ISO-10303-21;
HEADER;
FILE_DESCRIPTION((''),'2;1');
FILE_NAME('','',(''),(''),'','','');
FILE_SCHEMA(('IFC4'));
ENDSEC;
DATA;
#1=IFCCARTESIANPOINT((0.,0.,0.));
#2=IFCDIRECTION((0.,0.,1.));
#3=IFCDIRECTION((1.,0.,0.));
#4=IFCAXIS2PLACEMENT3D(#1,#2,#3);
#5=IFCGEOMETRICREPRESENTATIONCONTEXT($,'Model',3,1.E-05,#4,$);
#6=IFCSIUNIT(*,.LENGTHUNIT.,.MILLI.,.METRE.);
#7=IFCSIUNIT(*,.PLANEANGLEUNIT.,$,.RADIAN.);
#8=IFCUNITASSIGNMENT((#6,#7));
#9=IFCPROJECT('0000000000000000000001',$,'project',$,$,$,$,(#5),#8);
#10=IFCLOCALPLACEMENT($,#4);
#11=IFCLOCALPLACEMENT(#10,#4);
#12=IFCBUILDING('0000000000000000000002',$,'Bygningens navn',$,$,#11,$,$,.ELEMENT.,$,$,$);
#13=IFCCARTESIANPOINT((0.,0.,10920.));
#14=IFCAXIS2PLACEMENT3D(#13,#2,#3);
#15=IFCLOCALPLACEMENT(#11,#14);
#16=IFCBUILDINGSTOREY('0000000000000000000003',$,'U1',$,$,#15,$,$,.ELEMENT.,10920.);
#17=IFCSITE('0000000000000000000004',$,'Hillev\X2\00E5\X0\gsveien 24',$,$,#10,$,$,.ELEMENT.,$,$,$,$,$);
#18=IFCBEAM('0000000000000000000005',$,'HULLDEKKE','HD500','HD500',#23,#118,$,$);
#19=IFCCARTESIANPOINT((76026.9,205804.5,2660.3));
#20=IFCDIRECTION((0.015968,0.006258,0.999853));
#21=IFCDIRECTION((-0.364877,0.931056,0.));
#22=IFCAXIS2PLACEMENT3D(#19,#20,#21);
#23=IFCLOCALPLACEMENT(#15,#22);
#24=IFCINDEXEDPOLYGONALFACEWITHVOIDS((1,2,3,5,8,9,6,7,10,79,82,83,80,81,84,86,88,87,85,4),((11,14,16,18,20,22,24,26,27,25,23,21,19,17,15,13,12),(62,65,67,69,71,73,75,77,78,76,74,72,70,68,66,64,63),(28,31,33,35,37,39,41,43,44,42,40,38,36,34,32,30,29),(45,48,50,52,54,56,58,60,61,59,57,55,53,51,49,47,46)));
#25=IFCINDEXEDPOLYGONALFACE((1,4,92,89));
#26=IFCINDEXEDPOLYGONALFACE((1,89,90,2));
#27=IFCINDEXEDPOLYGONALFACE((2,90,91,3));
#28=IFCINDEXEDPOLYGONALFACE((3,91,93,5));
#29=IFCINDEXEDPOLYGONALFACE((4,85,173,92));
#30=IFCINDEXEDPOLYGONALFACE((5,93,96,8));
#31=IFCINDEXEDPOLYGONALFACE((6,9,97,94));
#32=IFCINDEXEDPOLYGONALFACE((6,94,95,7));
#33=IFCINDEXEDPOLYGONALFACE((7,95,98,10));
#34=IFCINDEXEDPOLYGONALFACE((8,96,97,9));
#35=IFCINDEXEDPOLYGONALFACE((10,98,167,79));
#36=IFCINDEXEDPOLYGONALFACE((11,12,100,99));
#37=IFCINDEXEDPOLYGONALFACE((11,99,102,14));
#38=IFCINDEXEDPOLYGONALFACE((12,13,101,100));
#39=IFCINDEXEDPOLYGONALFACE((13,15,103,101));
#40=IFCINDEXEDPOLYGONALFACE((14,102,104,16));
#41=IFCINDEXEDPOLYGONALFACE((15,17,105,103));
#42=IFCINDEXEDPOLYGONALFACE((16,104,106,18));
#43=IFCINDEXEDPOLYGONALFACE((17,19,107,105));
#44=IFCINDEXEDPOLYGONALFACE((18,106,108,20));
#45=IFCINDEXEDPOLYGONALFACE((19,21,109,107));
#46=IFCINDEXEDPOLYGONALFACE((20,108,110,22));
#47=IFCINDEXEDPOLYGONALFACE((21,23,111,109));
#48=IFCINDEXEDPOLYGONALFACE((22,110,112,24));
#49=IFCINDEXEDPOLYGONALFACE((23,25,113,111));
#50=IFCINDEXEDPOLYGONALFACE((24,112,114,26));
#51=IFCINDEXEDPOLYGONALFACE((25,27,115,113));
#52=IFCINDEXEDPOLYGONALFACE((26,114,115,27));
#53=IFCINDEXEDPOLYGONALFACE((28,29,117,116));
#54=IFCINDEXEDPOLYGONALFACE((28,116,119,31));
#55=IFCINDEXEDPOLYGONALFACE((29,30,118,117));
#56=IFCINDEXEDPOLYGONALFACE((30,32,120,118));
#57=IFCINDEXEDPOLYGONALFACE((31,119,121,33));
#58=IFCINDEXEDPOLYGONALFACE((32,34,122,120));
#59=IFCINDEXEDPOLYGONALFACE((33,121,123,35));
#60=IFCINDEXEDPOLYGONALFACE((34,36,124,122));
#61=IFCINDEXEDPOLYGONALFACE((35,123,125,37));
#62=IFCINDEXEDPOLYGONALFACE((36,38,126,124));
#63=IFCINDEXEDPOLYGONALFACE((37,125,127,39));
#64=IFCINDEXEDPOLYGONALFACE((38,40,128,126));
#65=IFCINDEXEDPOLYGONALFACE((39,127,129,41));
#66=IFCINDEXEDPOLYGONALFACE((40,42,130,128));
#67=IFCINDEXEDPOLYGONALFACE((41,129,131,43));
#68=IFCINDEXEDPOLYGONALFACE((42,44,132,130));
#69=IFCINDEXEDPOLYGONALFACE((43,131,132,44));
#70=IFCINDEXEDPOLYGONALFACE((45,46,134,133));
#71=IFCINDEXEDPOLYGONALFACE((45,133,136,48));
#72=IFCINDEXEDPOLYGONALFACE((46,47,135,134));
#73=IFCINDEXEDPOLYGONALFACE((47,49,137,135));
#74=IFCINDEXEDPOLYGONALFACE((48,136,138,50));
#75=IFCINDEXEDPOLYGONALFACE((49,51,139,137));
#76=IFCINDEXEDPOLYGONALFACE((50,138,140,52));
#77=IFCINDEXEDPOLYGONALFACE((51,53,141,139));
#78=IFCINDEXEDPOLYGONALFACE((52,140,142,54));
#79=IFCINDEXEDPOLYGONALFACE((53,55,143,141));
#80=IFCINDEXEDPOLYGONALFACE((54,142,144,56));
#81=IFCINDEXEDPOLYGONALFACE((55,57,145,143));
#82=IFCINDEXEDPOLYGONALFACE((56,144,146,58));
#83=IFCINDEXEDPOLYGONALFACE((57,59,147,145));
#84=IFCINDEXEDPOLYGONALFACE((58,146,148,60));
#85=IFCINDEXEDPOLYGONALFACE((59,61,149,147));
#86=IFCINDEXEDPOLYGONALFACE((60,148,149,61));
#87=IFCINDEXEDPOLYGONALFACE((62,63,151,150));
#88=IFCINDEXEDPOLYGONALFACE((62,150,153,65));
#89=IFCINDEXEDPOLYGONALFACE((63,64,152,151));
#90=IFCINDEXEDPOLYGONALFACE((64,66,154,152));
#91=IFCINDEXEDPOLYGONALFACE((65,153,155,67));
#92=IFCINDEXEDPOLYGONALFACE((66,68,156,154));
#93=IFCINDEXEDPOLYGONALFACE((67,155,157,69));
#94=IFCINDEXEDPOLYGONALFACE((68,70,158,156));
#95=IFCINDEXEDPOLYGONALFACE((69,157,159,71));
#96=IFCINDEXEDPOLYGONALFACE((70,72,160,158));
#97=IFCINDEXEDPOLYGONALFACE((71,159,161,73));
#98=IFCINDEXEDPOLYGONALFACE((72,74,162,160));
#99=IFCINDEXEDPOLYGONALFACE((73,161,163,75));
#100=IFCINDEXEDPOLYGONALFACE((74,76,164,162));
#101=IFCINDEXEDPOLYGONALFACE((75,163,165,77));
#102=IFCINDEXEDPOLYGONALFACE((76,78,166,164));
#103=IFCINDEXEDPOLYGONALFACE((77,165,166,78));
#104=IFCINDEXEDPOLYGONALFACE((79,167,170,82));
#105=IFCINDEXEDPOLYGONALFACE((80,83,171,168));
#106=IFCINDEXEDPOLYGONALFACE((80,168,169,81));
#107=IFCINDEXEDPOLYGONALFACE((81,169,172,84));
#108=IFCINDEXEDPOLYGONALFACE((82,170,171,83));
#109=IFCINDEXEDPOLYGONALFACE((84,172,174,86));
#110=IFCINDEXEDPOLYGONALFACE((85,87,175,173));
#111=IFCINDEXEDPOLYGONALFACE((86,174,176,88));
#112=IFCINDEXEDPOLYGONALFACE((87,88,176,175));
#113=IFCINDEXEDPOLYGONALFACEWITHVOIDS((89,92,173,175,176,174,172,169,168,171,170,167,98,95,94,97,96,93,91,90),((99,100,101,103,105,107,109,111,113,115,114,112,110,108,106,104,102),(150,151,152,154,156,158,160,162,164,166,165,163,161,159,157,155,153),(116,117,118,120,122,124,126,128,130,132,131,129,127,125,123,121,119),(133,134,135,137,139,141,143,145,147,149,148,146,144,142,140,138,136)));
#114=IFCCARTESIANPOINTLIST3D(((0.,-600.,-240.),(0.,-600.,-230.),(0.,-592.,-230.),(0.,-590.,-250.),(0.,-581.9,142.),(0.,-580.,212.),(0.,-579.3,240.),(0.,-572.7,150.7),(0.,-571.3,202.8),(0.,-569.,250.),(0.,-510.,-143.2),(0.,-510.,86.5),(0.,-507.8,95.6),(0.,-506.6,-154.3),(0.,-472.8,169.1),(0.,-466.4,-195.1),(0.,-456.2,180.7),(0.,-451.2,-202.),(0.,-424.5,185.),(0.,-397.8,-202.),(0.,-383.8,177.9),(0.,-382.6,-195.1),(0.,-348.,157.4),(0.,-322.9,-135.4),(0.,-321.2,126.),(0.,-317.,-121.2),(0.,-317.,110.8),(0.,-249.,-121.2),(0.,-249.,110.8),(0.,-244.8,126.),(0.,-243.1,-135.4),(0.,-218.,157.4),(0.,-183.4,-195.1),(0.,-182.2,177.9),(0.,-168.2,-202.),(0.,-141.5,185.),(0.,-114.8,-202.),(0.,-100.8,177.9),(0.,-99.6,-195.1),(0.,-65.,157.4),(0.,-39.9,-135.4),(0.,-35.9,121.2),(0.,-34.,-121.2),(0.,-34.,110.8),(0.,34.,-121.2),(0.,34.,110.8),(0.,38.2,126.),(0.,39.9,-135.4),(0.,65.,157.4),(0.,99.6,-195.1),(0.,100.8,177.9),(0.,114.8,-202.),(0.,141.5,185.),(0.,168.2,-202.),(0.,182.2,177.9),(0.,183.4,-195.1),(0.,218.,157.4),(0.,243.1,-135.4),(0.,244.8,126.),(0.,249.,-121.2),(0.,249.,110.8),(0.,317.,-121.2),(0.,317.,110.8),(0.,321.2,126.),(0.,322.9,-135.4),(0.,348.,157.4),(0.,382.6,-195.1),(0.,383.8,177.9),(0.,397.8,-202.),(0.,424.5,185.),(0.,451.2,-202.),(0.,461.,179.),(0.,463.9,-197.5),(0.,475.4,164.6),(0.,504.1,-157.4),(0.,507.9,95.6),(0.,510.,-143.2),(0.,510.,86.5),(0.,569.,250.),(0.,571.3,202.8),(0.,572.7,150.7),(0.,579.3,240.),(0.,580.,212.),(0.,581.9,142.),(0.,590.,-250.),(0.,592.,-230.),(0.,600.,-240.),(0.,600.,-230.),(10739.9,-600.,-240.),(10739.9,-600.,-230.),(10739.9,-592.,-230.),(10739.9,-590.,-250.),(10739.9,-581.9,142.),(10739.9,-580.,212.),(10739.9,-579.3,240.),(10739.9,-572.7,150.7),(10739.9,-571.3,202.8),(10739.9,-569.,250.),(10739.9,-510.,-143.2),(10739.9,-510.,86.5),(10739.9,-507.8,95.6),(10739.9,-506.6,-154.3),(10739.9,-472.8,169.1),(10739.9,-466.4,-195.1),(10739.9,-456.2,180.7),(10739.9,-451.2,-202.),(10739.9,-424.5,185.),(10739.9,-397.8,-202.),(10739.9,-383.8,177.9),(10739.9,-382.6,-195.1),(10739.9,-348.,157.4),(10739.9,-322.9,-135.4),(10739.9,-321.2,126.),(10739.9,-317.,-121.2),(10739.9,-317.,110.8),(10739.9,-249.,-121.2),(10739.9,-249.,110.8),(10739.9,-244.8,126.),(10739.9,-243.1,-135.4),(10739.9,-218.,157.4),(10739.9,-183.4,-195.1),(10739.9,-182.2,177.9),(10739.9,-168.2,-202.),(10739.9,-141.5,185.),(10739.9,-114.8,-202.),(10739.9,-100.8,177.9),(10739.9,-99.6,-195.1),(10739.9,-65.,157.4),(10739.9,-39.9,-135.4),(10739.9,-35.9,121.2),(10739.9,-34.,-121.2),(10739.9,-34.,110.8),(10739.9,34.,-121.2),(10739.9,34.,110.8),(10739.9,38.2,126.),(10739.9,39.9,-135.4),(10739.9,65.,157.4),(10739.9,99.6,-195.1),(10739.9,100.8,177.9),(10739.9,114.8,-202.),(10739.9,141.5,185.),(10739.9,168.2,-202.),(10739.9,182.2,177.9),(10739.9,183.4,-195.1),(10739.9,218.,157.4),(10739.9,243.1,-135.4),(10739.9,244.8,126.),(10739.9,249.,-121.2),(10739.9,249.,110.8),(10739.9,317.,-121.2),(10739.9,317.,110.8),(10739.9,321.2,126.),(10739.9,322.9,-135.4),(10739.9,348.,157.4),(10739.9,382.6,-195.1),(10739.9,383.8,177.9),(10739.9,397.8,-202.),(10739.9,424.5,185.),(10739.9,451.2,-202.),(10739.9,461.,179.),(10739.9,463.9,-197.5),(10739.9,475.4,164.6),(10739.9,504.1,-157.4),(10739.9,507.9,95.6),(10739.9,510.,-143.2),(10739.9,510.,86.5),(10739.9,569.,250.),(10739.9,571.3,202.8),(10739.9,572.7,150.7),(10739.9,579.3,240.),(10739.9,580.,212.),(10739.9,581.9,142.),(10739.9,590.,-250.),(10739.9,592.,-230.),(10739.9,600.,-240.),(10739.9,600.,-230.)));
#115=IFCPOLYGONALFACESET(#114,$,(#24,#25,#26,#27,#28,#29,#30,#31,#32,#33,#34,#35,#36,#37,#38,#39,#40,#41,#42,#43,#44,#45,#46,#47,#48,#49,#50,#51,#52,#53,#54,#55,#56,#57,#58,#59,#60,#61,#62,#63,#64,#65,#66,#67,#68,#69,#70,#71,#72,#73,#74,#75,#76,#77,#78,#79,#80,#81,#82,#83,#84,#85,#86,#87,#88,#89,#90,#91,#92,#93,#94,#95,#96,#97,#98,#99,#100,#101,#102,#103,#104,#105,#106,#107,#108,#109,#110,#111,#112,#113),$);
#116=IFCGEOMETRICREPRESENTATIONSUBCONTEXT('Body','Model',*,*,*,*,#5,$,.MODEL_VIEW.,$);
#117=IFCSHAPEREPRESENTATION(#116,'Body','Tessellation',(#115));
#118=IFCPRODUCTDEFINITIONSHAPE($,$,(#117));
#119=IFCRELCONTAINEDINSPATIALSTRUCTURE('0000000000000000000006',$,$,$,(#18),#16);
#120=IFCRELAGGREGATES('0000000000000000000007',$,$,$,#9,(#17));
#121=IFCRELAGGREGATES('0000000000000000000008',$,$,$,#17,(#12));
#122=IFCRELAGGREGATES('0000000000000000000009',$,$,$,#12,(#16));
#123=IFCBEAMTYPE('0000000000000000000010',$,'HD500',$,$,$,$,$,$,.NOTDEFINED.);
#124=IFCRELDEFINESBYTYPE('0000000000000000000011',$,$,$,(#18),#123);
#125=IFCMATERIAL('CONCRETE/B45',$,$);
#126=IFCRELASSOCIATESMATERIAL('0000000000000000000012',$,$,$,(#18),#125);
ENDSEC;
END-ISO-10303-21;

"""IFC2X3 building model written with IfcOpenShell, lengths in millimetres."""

from ifc_helpers import new_model, si_unit, frame, origin_with_axes, place, context, subcontext, project, spatial, polyline, outline, extrude, material, type_object, element, save


model = new_model("IFC2X3")

# Units and contexts
model_context = context("Model", 3, precision=1e-05, world=origin_with_axes())
body_context = subcontext(model_context, "Body", "Model", "MODEL_VIEW")
ifc_project = project(units=[si_unit("LENGTHUNIT", "METRE", prefix="MILLI"), si_unit("PLANEANGLEUNIT", "RADIAN")], contexts=[model_context])

# Site, building, storey
site_placement = place(None, origin_with_axes())
site = spatial("IfcSite", under=ifc_project, at=site_placement, Name="Hillevågsveien 24", CompositionType="ELEMENT")
building_placement = place(site_placement, origin_with_axes())
building = spatial("IfcBuilding", under=site, at=building_placement, Name="Bygningens navn", CompositionType="ELEMENT")
storey_placement = place(building_placement, frame((0.0, 0.0, 10920.0), z_axis=(0.0, 0.0, 1.0), x_axis=(1.0, 0.0, 0.0)))
storey = spatial("IfcBuildingStorey", under=building, at=storey_placement, Name="U1", CompositionType="ELEMENT", Elevation=10920.0)

# Beam
ifc_material_1 = material(Name="CONCRETE/B45")
beam_type_1 = type_object("IfcBeamType", Name="HD500", PredefinedType="NOTDEFINED")
beam_1_placement = place(storey_placement, frame((76026.9, 205804.5, 2660.3), z_axis=(0.015968, 0.006258, 0.999853), x_axis=(-0.364877, 0.931056, 0.0)))
element("IfcBeam", 1, at=beam_1_placement, inside=storey, type_object=beam_type_1, material=ifc_material_1, Name="HULLDEKKE", Description="HD500", ObjectType="HD500", context=body_context, shape_type="SweptSolid", body=[
    extrude(outline(polyline([(581.9, 142.0), (592.0, -230.0), (600.0, -230.0), (600.0, -240.0), (590.0, -250.0), (-590.0, -250.0), (-600.0, -240.0), (-600.0, -230.0), (-592.0, -230.0), (-581.9, 142.0), (-572.7, 150.7), (-571.3, 202.8), (-580.0, 212.0), (-579.3, 240.0), (-569.0, 250.0), (569.0, 250.0), (579.3, 240.0), (580.0, 212.0), (571.3, 202.8), (572.7, 150.7), (581.9, 142.0)]), holes=[polyline([(466.4, -195.1), (506.6, -154.3), (510.0, -143.2), (510.0, 86.5), (507.8, 95.6), (472.8, 169.1), (456.2, 180.7), (424.5, 185.0), (383.8, 177.9), (348.0, 157.4), (321.2, 126.0), (317.0, 110.8), (317.0, -121.2), (322.9, -135.4), (382.6, -195.1), (397.8, -202.0), (451.2, -202.0), (466.4, -195.1)]), polyline([(183.4, -195.1), (243.1, -135.4), (249.0, -121.2), (249.0, 110.8), (244.8, 126.0), (218.0, 157.4), (182.2, 177.9), (141.5, 185.0), (100.8, 177.9), (65.0, 157.4), (35.9, 121.2), (34.0, 110.8), (34.0, -121.2), (39.9, -135.4), (99.6, -195.1), (114.8, -202.0), (168.2, -202.0), (183.4, -195.1)]), polyline([(-99.6, -195.1), (-39.9, -135.4), (-34.0, -121.2), (-34.0, 110.8), (-38.2, 126.0), (-65.0, 157.4), (-100.8, 177.9), (-141.5, 185.0), (-182.2, 177.9), (-218.0, 157.4), (-244.8, 126.0), (-249.0, 110.8), (-249.0, -121.2), (-243.1, -135.4), (-183.4, -195.1), (-168.2, -202.0), (-114.8, -202.0), (-99.6, -195.1)]), polyline([(-382.6, -195.1), (-322.9, -135.4), (-317.0, -121.2), (-317.0, 110.8), (-321.2, 126.0), (-348.0, 157.4), (-383.8, 177.9), (-424.5, 185.0), (-461.0, 179.0), (-475.4, 164.6), (-507.9, 95.6), (-510.0, 86.5), (-510.0, -143.2), (-504.1, -157.4), (-463.9, -197.5), (-451.2, -202.0), (-397.8, -202.0), (-382.6, -195.1)])]), frame((10739.9, 0.0, 0.0), z_axis=(-1.0, 0.0, 0.0), x_axis=(0.0, -1.0, 0.0)), (0.0, 0.0, 1.0), 10739.9),
])

save(model, "model.ifc")
